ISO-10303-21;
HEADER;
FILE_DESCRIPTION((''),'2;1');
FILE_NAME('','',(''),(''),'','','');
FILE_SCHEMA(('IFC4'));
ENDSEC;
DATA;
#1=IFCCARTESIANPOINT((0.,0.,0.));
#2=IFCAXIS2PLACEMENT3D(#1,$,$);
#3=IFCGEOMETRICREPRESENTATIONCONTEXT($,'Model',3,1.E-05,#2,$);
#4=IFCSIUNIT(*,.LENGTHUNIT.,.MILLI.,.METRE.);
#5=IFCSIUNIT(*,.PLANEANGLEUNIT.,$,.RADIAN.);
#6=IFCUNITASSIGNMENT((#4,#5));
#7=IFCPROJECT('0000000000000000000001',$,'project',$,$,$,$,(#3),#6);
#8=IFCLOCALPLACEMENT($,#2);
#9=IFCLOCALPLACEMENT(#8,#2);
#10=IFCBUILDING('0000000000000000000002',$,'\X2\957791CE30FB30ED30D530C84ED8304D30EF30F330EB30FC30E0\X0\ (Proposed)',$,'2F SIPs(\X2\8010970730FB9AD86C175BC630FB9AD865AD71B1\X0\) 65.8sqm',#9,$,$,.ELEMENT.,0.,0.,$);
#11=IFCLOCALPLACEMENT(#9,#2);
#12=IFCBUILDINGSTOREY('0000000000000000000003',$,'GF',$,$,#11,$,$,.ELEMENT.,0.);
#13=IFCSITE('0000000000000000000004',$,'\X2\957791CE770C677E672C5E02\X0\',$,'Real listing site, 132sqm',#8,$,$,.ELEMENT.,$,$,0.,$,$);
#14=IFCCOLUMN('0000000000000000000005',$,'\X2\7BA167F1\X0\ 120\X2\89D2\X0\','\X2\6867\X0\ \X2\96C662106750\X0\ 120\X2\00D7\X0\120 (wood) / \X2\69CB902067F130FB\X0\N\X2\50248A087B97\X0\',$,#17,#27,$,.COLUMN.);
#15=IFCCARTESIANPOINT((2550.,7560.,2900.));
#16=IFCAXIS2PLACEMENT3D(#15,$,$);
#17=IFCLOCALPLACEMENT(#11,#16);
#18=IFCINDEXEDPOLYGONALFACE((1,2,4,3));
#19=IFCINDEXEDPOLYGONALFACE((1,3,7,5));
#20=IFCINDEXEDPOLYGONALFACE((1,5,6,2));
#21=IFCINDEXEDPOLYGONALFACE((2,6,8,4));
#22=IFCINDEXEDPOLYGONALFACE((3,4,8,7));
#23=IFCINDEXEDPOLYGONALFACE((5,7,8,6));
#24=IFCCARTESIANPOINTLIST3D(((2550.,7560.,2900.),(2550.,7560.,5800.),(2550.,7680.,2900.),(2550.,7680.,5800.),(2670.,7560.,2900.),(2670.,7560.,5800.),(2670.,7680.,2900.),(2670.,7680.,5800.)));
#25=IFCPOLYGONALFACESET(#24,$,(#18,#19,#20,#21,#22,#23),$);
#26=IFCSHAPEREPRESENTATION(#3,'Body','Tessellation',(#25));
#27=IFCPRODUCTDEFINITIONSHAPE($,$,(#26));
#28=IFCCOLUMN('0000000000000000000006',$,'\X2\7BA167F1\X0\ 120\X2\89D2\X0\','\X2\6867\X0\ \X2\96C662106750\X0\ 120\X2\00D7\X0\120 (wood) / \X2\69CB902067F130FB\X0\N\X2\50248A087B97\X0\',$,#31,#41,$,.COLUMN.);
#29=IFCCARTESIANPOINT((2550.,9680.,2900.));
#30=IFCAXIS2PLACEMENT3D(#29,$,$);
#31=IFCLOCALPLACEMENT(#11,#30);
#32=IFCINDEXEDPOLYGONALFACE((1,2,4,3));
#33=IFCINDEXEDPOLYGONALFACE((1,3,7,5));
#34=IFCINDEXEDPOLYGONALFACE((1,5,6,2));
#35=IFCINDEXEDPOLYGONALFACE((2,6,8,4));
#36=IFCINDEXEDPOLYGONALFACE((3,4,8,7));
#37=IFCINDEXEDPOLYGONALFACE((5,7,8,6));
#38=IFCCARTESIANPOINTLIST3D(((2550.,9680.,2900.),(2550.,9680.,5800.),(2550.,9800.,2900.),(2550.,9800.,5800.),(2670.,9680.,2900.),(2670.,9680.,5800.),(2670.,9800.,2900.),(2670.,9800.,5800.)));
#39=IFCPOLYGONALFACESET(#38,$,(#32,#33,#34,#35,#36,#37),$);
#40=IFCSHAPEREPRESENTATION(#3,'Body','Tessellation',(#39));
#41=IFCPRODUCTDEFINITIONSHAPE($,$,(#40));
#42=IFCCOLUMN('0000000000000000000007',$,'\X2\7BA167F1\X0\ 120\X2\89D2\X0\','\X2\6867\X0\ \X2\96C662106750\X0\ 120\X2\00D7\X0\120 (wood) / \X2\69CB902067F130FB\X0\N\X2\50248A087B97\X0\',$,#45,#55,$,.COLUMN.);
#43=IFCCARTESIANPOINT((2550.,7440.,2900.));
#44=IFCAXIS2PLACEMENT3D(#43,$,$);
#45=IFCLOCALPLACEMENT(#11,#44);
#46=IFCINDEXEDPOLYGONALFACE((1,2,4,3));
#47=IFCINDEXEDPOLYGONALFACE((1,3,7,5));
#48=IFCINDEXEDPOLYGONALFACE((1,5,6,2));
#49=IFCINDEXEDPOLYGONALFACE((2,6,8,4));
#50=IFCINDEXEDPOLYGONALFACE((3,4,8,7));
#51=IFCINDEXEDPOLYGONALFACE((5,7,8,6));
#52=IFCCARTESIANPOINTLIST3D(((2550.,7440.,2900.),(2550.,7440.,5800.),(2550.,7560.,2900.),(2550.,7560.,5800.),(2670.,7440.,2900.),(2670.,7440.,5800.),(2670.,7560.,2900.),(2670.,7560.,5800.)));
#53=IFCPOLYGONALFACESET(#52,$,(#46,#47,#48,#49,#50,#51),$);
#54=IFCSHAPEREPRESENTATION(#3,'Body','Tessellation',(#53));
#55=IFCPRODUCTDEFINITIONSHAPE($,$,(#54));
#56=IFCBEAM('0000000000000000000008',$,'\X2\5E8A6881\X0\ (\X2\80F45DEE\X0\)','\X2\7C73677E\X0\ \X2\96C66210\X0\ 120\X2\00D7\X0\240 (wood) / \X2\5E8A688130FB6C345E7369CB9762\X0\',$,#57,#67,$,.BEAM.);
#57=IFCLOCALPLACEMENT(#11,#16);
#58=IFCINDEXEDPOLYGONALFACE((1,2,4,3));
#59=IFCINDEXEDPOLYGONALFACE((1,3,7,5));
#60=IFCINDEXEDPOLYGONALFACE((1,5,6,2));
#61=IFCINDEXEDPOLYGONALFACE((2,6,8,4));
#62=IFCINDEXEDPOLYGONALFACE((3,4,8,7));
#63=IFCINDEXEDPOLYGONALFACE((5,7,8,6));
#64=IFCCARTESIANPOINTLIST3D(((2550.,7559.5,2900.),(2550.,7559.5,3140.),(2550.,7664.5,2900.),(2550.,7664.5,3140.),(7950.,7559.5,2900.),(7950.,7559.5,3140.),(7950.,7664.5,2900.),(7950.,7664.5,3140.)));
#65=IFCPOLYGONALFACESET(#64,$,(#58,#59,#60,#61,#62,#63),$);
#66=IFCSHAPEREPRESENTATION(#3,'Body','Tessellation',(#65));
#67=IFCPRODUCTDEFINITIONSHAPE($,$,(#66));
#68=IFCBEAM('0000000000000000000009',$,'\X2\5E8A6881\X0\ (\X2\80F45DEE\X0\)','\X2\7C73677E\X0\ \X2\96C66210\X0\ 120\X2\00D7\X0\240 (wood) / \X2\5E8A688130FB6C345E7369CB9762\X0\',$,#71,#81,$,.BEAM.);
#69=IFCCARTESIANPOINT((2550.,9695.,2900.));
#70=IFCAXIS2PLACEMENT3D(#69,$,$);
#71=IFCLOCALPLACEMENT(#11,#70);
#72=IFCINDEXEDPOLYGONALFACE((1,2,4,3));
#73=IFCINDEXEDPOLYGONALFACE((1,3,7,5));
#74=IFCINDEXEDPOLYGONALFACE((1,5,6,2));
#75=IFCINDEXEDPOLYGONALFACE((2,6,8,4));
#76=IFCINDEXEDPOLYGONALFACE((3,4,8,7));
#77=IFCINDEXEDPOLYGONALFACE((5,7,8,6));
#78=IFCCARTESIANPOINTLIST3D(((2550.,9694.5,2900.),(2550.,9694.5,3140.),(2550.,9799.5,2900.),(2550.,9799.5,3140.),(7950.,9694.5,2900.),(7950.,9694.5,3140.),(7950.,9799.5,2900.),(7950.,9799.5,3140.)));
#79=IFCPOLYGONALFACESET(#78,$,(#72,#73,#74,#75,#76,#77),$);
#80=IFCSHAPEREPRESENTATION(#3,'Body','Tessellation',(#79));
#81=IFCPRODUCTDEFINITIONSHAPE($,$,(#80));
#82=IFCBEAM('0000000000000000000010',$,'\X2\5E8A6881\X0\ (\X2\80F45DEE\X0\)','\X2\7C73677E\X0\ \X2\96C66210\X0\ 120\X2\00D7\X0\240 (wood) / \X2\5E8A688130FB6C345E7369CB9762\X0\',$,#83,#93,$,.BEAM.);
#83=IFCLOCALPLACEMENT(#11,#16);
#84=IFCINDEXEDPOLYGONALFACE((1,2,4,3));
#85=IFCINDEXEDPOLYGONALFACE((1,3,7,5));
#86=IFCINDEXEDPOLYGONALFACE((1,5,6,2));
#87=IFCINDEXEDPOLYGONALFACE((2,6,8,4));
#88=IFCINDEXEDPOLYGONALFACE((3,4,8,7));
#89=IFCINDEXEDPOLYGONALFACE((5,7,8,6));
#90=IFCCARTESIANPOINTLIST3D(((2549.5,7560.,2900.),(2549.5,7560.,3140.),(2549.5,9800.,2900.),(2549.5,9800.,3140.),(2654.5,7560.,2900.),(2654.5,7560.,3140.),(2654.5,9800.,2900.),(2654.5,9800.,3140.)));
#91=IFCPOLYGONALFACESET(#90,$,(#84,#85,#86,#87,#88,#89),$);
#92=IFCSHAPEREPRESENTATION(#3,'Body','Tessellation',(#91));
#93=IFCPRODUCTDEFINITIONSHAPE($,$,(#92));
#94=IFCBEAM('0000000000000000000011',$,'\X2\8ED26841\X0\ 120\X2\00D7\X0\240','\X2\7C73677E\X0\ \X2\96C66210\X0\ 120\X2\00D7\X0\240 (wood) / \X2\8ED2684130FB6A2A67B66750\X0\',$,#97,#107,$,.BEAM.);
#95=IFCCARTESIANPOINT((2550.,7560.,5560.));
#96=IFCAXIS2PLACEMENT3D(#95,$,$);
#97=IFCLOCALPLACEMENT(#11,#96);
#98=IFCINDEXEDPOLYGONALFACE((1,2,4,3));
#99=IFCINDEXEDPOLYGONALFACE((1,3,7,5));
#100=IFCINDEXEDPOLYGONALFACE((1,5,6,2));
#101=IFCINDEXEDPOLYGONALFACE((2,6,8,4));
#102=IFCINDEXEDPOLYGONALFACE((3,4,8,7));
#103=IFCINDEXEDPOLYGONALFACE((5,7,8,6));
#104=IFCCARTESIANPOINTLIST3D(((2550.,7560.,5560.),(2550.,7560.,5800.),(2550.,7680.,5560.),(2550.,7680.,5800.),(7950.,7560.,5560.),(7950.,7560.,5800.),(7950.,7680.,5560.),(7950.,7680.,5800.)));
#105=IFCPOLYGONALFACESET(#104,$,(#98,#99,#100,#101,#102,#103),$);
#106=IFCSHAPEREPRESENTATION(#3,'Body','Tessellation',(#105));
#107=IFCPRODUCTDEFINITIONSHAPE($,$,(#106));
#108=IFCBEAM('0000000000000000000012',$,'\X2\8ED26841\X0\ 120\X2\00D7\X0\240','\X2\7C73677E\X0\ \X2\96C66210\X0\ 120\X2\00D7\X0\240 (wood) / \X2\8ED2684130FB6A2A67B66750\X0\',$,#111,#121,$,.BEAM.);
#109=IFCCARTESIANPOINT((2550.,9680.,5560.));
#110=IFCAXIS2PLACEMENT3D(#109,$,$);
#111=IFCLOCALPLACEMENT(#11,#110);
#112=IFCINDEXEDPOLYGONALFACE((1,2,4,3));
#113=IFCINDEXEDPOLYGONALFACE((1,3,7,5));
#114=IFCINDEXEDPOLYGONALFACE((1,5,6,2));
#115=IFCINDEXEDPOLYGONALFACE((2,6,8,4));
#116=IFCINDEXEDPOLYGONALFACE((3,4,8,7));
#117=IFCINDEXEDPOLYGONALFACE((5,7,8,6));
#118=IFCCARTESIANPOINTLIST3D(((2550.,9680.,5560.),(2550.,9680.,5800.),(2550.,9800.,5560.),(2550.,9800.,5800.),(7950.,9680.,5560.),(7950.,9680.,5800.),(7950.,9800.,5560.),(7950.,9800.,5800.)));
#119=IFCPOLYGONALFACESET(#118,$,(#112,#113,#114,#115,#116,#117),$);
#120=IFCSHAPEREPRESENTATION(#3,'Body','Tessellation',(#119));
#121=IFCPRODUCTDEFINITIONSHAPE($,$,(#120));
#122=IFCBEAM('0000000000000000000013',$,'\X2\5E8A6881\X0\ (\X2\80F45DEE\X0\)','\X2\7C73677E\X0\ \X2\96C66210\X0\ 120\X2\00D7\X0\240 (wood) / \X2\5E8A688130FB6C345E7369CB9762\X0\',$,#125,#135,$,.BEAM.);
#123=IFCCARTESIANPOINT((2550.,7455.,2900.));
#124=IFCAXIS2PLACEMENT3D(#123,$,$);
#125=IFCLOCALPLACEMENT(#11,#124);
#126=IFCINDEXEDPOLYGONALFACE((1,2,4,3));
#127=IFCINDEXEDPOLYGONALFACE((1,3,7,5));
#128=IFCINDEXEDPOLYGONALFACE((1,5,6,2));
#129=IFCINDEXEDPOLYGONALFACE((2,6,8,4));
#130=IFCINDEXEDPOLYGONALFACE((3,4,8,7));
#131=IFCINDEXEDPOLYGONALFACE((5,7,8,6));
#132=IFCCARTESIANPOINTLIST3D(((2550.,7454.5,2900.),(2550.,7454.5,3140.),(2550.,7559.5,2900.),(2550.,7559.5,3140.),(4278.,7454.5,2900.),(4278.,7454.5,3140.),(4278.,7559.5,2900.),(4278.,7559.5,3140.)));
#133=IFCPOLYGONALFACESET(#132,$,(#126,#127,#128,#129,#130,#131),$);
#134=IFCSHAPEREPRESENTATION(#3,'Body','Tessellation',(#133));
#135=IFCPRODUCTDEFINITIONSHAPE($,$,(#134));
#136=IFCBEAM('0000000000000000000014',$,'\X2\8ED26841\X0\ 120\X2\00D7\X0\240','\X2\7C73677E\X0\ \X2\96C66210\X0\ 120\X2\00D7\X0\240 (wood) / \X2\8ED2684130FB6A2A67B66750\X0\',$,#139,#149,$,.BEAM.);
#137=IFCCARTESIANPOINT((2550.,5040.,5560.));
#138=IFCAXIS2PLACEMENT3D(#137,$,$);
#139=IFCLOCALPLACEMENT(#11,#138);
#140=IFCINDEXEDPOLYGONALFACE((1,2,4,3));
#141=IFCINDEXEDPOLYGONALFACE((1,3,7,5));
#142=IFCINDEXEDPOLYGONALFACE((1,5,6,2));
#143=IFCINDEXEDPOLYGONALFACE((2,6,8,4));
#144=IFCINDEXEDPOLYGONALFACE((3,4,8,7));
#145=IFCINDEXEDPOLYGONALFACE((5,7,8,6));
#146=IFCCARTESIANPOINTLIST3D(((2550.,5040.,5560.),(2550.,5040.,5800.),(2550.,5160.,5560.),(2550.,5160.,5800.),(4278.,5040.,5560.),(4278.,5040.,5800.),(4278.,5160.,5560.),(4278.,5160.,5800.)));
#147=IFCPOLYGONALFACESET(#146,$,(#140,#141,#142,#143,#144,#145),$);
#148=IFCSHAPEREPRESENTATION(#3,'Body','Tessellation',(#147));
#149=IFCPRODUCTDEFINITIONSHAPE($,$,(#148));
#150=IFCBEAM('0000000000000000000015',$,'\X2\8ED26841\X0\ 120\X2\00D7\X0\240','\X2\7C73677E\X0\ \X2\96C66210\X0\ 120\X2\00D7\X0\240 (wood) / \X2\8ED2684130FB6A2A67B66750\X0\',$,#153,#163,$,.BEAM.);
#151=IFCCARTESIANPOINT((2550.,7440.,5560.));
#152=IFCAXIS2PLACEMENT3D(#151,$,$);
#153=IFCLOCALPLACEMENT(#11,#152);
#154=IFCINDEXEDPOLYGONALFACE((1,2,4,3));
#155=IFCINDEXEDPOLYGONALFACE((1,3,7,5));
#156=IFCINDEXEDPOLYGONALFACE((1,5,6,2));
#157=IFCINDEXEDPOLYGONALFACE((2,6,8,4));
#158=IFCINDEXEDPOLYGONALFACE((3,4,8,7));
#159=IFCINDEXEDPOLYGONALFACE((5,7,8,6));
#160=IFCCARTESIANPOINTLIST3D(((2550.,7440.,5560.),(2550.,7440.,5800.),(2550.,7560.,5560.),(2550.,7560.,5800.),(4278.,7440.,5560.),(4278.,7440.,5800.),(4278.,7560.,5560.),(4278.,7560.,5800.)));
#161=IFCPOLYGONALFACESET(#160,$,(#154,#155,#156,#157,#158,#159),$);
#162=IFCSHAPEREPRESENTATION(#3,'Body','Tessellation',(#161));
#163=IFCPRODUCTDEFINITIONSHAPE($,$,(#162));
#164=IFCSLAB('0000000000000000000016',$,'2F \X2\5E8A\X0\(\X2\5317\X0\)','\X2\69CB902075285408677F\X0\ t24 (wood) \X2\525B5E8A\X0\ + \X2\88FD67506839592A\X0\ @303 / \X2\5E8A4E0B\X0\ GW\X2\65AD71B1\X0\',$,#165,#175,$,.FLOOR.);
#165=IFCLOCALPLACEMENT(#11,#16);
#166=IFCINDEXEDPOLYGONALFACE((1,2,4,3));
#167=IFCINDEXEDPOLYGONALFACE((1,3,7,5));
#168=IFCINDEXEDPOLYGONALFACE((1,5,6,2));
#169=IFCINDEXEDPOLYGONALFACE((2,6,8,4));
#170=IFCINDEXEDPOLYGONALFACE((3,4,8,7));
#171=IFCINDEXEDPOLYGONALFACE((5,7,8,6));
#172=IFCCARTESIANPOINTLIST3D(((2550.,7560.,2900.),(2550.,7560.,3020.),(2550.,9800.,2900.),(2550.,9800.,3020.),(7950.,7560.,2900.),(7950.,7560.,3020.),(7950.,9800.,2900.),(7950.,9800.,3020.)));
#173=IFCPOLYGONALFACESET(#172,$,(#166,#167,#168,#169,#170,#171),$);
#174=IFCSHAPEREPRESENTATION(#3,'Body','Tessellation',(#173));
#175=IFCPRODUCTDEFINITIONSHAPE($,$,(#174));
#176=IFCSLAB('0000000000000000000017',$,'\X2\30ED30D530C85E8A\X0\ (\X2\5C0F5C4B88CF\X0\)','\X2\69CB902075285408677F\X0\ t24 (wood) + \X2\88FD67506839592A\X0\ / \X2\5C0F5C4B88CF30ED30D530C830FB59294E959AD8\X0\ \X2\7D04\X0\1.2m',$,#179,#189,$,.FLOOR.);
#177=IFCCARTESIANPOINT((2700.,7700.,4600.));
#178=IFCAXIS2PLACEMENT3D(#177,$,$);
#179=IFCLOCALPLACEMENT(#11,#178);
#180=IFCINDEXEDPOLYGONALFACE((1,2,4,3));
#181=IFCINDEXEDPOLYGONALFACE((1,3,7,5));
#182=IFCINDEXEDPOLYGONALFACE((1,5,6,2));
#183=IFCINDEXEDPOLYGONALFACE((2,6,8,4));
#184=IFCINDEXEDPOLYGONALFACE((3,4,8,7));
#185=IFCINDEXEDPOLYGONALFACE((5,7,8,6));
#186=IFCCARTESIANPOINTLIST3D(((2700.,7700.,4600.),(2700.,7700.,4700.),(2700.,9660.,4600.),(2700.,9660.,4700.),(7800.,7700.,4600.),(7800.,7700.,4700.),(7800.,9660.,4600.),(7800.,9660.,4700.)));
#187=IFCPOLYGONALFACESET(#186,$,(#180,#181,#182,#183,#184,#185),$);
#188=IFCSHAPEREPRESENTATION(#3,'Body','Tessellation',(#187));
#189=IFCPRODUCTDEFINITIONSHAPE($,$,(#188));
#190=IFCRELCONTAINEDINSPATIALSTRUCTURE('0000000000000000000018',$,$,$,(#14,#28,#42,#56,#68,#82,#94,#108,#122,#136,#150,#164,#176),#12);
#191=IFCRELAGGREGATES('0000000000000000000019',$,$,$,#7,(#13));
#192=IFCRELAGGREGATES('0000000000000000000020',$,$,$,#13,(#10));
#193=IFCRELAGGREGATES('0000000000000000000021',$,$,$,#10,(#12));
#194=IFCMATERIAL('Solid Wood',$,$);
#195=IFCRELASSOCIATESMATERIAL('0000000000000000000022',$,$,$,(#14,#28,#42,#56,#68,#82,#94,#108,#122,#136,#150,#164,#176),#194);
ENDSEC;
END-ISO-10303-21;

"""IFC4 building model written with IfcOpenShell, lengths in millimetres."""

from ifc_helpers import new_model, si_unit, frame, frame_2d, origin, place, context, project, spatial, rectangle, extrude, material, element, save


model = new_model("IFC4")

# Units and contexts
model_context = context("Model", 3, precision=1e-05, world=origin())
ifc_project = project(units=[si_unit("LENGTHUNIT", "METRE", prefix="MILLI"), si_unit("PLANEANGLEUNIT", "RADIAN")], contexts=[model_context])

# Site, building, storey
site_placement = place(None, origin())
site = spatial("IfcSite", under=ifc_project, at=site_placement, Name="長野県松本市", ObjectType="Real listing site, 132sqm", CompositionType="ELEMENT", RefElevation=0.0)
building_placement = place(site_placement, origin())
building = spatial("IfcBuilding", under=site, at=building_placement, Name="長野・ロフト付きワンルーム (Proposed)", ObjectType="2F SIPs(耐震・高気密・高断熱) 65.8sqm", CompositionType="ELEMENT", ElevationOfRefHeight=0.0, ElevationOfTerrain=0.0)
storey_placement = place(building_placement, origin())
storey = spatial("IfcBuildingStorey", under=building, at=storey_placement, Name="GF", CompositionType="ELEMENT", Elevation=0.0)

# Columns
ifc_material_1 = material(Name="Solid Wood")
column_1_placement = place(storey_placement, frame((2550.0, 7560.0, 2900.0)))
element("IfcColumn", 1, at=column_1_placement, inside=storey, material=ifc_material_1, Name="管柱 120角", Description="桧 集成材 120×120 (wood) / 構造柱・N値計算", PredefinedType="COLUMN", context=model_context, shape_type="SweptSolid", body=[
    extrude(rectangle(XDim=120.0, YDim=120.0, at=frame_2d((60.0, 60.0))), frame((2550.0, 7560.0, 2900.0)), (0.0, 0.0, 1.0), 2900.0),
])
column_2_placement = place(storey_placement, frame((2550.0, 9680.0, 2900.0)))
element("IfcColumn", 2, at=column_2_placement, inside=storey, material=ifc_material_1, Name="管柱 120角", Description="桧 集成材 120×120 (wood) / 構造柱・N値計算", PredefinedType="COLUMN", context=model_context, shape_type="SweptSolid", body=[
    extrude(rectangle(XDim=120.0, YDim=120.0, at=frame_2d((60.0, 60.0))), frame((2550.0, 9680.0, 2900.0)), (0.0, 0.0, 1.0), 2900.0),
])
column_3_placement = place(storey_placement, frame((2550.0, 7440.0, 2900.0)))
element("IfcColumn", 3, at=column_3_placement, inside=storey, material=ifc_material_1, Name="管柱 120角", Description="桧 集成材 120×120 (wood) / 構造柱・N値計算", PredefinedType="COLUMN", context=model_context, shape_type="SweptSolid", body=[
    extrude(rectangle(XDim=120.0, YDim=120.0, at=frame_2d((60.0, 60.0))), frame((2550.0, 7440.0, 2900.0)), (0.0, 0.0, 1.0), 2900.0),
])

# Beams
beam_1_placement = place(storey_placement, frame((2550.0, 7560.0, 2900.0)))
element("IfcBeam", 4, at=beam_1_placement, inside=storey, material=ifc_material_1, Name="床梁 (胴差)", Description="米松 集成 120×240 (wood) / 床梁・水平構面", PredefinedType="BEAM", context=model_context, shape_type="SweptSolid", body=[
    extrude(rectangle(XDim=5400.0, YDim=105.0, at=frame_2d((2700.0, 52.0))), frame((2550.0, 7560.0, 2900.0)), (0.0, 0.0, 1.0), 240.0),
])
beam_2_placement = place(storey_placement, frame((2550.0, 9695.0, 2900.0)))
element("IfcBeam", 5, at=beam_2_placement, inside=storey, material=ifc_material_1, Name="床梁 (胴差)", Description="米松 集成 120×240 (wood) / 床梁・水平構面", PredefinedType="BEAM", context=model_context, shape_type="SweptSolid", body=[
    extrude(rectangle(XDim=5400.0, YDim=105.0, at=frame_2d((2700.0, 52.0))), frame((2550.0, 9695.0, 2900.0)), (0.0, 0.0, 1.0), 240.0),
])
beam_3_placement = place(storey_placement, frame((2550.0, 7560.0, 2900.0)))
element("IfcBeam", 6, at=beam_3_placement, inside=storey, material=ifc_material_1, Name="床梁 (胴差)", Description="米松 集成 120×240 (wood) / 床梁・水平構面", PredefinedType="BEAM", context=model_context, shape_type="SweptSolid", body=[
    extrude(rectangle(XDim=105.0, YDim=2240.0, at=frame_2d((52.0, 1120.0))), frame((2550.0, 7560.0, 2900.0)), (0.0, 0.0, 1.0), 240.0),
])
beam_4_placement = place(storey_placement, frame((2550.0, 7560.0, 5560.0)))
element("IfcBeam", 7, at=beam_4_placement, inside=storey, material=ifc_material_1, Name="軒桁 120×240", Description="米松 集成 120×240 (wood) / 軒桁・横架材", PredefinedType="BEAM", context=model_context, shape_type="SweptSolid", body=[
    extrude(rectangle(XDim=5400.0, YDim=120.0, at=frame_2d((2700.0, 60.0))), frame((2550.0, 7560.0, 5560.0)), (0.0, 0.0, 1.0), 240.0),
])
beam_5_placement = place(storey_placement, frame((2550.0, 9680.0, 5560.0)))
element("IfcBeam", 8, at=beam_5_placement, inside=storey, material=ifc_material_1, Name="軒桁 120×240", Description="米松 集成 120×240 (wood) / 軒桁・横架材", PredefinedType="BEAM", context=model_context, shape_type="SweptSolid", body=[
    extrude(rectangle(XDim=5400.0, YDim=120.0, at=frame_2d((2700.0, 60.0))), frame((2550.0, 9680.0, 5560.0)), (0.0, 0.0, 1.0), 240.0),
])
beam_6_placement = place(storey_placement, frame((2550.0, 7455.0, 2900.0)))
element("IfcBeam", 9, at=beam_6_placement, inside=storey, material=ifc_material_1, Name="床梁 (胴差)", Description="米松 集成 120×240 (wood) / 床梁・水平構面", PredefinedType="BEAM", context=model_context, shape_type="SweptSolid", body=[
    extrude(rectangle(XDim=1728.0, YDim=105.0, at=frame_2d((864.0, 52.0))), frame((2550.0, 7455.0, 2900.0)), (0.0, 0.0, 1.0), 240.0),
])
beam_7_placement = place(storey_placement, frame((2550.0, 5040.0, 5560.0)))
element("IfcBeam", 10, at=beam_7_placement, inside=storey, material=ifc_material_1, Name="軒桁 120×240", Description="米松 集成 120×240 (wood) / 軒桁・横架材", PredefinedType="BEAM", context=model_context, shape_type="SweptSolid", body=[
    extrude(rectangle(XDim=1728.0, YDim=120.0, at=frame_2d((864.0, 60.0))), frame((2550.0, 5040.0, 5560.0)), (0.0, 0.0, 1.0), 240.0),
])
beam_8_placement = place(storey_placement, frame((2550.0, 7440.0, 5560.0)))
element("IfcBeam", 11, at=beam_8_placement, inside=storey, material=ifc_material_1, Name="軒桁 120×240", Description="米松 集成 120×240 (wood) / 軒桁・横架材", PredefinedType="BEAM", context=model_context, shape_type="SweptSolid", body=[
    extrude(rectangle(XDim=1728.0, YDim=120.0, at=frame_2d((864.0, 60.0))), frame((2550.0, 7440.0, 5560.0)), (0.0, 0.0, 1.0), 240.0),
])

# Slabs
slab_1_placement = place(storey_placement, frame((2550.0, 7560.0, 2900.0)))
element("IfcSlab", 12, at=slab_1_placement, inside=storey, material=ifc_material_1, Name="2F 床(北)", Description="構造用合板 t24 (wood) 剛床 + 製材根太 @303 / 床下 GW断熱", PredefinedType="FLOOR", context=model_context, shape_type="SweptSolid", body=[
    extrude(rectangle(XDim=5400.0, YDim=2240.0, at=frame_2d((2700.0, 1120.0))), frame((2550.0, 7560.0, 2900.0)), (0.0, 0.0, 1.0), 120.0),
])
slab_2_placement = place(storey_placement, frame((2700.0, 7700.0, 4600.0)))
element("IfcSlab", 13, at=slab_2_placement, inside=storey, material=ifc_material_1, Name="ロフト床 (小屋裏)", Description="構造用合板 t24 (wood) + 製材根太 / 小屋裏ロフト・天井高 約1.2m", PredefinedType="FLOOR", context=model_context, shape_type="SweptSolid", body=[
    extrude(rectangle(XDim=5100.0, YDim=1960.0, at=frame_2d((2550.0, 980.0))), frame((2700.0, 7700.0, 4600.0)), (0.0, 0.0, 1.0), 100.0),
])

save(model, "model.ifc")
